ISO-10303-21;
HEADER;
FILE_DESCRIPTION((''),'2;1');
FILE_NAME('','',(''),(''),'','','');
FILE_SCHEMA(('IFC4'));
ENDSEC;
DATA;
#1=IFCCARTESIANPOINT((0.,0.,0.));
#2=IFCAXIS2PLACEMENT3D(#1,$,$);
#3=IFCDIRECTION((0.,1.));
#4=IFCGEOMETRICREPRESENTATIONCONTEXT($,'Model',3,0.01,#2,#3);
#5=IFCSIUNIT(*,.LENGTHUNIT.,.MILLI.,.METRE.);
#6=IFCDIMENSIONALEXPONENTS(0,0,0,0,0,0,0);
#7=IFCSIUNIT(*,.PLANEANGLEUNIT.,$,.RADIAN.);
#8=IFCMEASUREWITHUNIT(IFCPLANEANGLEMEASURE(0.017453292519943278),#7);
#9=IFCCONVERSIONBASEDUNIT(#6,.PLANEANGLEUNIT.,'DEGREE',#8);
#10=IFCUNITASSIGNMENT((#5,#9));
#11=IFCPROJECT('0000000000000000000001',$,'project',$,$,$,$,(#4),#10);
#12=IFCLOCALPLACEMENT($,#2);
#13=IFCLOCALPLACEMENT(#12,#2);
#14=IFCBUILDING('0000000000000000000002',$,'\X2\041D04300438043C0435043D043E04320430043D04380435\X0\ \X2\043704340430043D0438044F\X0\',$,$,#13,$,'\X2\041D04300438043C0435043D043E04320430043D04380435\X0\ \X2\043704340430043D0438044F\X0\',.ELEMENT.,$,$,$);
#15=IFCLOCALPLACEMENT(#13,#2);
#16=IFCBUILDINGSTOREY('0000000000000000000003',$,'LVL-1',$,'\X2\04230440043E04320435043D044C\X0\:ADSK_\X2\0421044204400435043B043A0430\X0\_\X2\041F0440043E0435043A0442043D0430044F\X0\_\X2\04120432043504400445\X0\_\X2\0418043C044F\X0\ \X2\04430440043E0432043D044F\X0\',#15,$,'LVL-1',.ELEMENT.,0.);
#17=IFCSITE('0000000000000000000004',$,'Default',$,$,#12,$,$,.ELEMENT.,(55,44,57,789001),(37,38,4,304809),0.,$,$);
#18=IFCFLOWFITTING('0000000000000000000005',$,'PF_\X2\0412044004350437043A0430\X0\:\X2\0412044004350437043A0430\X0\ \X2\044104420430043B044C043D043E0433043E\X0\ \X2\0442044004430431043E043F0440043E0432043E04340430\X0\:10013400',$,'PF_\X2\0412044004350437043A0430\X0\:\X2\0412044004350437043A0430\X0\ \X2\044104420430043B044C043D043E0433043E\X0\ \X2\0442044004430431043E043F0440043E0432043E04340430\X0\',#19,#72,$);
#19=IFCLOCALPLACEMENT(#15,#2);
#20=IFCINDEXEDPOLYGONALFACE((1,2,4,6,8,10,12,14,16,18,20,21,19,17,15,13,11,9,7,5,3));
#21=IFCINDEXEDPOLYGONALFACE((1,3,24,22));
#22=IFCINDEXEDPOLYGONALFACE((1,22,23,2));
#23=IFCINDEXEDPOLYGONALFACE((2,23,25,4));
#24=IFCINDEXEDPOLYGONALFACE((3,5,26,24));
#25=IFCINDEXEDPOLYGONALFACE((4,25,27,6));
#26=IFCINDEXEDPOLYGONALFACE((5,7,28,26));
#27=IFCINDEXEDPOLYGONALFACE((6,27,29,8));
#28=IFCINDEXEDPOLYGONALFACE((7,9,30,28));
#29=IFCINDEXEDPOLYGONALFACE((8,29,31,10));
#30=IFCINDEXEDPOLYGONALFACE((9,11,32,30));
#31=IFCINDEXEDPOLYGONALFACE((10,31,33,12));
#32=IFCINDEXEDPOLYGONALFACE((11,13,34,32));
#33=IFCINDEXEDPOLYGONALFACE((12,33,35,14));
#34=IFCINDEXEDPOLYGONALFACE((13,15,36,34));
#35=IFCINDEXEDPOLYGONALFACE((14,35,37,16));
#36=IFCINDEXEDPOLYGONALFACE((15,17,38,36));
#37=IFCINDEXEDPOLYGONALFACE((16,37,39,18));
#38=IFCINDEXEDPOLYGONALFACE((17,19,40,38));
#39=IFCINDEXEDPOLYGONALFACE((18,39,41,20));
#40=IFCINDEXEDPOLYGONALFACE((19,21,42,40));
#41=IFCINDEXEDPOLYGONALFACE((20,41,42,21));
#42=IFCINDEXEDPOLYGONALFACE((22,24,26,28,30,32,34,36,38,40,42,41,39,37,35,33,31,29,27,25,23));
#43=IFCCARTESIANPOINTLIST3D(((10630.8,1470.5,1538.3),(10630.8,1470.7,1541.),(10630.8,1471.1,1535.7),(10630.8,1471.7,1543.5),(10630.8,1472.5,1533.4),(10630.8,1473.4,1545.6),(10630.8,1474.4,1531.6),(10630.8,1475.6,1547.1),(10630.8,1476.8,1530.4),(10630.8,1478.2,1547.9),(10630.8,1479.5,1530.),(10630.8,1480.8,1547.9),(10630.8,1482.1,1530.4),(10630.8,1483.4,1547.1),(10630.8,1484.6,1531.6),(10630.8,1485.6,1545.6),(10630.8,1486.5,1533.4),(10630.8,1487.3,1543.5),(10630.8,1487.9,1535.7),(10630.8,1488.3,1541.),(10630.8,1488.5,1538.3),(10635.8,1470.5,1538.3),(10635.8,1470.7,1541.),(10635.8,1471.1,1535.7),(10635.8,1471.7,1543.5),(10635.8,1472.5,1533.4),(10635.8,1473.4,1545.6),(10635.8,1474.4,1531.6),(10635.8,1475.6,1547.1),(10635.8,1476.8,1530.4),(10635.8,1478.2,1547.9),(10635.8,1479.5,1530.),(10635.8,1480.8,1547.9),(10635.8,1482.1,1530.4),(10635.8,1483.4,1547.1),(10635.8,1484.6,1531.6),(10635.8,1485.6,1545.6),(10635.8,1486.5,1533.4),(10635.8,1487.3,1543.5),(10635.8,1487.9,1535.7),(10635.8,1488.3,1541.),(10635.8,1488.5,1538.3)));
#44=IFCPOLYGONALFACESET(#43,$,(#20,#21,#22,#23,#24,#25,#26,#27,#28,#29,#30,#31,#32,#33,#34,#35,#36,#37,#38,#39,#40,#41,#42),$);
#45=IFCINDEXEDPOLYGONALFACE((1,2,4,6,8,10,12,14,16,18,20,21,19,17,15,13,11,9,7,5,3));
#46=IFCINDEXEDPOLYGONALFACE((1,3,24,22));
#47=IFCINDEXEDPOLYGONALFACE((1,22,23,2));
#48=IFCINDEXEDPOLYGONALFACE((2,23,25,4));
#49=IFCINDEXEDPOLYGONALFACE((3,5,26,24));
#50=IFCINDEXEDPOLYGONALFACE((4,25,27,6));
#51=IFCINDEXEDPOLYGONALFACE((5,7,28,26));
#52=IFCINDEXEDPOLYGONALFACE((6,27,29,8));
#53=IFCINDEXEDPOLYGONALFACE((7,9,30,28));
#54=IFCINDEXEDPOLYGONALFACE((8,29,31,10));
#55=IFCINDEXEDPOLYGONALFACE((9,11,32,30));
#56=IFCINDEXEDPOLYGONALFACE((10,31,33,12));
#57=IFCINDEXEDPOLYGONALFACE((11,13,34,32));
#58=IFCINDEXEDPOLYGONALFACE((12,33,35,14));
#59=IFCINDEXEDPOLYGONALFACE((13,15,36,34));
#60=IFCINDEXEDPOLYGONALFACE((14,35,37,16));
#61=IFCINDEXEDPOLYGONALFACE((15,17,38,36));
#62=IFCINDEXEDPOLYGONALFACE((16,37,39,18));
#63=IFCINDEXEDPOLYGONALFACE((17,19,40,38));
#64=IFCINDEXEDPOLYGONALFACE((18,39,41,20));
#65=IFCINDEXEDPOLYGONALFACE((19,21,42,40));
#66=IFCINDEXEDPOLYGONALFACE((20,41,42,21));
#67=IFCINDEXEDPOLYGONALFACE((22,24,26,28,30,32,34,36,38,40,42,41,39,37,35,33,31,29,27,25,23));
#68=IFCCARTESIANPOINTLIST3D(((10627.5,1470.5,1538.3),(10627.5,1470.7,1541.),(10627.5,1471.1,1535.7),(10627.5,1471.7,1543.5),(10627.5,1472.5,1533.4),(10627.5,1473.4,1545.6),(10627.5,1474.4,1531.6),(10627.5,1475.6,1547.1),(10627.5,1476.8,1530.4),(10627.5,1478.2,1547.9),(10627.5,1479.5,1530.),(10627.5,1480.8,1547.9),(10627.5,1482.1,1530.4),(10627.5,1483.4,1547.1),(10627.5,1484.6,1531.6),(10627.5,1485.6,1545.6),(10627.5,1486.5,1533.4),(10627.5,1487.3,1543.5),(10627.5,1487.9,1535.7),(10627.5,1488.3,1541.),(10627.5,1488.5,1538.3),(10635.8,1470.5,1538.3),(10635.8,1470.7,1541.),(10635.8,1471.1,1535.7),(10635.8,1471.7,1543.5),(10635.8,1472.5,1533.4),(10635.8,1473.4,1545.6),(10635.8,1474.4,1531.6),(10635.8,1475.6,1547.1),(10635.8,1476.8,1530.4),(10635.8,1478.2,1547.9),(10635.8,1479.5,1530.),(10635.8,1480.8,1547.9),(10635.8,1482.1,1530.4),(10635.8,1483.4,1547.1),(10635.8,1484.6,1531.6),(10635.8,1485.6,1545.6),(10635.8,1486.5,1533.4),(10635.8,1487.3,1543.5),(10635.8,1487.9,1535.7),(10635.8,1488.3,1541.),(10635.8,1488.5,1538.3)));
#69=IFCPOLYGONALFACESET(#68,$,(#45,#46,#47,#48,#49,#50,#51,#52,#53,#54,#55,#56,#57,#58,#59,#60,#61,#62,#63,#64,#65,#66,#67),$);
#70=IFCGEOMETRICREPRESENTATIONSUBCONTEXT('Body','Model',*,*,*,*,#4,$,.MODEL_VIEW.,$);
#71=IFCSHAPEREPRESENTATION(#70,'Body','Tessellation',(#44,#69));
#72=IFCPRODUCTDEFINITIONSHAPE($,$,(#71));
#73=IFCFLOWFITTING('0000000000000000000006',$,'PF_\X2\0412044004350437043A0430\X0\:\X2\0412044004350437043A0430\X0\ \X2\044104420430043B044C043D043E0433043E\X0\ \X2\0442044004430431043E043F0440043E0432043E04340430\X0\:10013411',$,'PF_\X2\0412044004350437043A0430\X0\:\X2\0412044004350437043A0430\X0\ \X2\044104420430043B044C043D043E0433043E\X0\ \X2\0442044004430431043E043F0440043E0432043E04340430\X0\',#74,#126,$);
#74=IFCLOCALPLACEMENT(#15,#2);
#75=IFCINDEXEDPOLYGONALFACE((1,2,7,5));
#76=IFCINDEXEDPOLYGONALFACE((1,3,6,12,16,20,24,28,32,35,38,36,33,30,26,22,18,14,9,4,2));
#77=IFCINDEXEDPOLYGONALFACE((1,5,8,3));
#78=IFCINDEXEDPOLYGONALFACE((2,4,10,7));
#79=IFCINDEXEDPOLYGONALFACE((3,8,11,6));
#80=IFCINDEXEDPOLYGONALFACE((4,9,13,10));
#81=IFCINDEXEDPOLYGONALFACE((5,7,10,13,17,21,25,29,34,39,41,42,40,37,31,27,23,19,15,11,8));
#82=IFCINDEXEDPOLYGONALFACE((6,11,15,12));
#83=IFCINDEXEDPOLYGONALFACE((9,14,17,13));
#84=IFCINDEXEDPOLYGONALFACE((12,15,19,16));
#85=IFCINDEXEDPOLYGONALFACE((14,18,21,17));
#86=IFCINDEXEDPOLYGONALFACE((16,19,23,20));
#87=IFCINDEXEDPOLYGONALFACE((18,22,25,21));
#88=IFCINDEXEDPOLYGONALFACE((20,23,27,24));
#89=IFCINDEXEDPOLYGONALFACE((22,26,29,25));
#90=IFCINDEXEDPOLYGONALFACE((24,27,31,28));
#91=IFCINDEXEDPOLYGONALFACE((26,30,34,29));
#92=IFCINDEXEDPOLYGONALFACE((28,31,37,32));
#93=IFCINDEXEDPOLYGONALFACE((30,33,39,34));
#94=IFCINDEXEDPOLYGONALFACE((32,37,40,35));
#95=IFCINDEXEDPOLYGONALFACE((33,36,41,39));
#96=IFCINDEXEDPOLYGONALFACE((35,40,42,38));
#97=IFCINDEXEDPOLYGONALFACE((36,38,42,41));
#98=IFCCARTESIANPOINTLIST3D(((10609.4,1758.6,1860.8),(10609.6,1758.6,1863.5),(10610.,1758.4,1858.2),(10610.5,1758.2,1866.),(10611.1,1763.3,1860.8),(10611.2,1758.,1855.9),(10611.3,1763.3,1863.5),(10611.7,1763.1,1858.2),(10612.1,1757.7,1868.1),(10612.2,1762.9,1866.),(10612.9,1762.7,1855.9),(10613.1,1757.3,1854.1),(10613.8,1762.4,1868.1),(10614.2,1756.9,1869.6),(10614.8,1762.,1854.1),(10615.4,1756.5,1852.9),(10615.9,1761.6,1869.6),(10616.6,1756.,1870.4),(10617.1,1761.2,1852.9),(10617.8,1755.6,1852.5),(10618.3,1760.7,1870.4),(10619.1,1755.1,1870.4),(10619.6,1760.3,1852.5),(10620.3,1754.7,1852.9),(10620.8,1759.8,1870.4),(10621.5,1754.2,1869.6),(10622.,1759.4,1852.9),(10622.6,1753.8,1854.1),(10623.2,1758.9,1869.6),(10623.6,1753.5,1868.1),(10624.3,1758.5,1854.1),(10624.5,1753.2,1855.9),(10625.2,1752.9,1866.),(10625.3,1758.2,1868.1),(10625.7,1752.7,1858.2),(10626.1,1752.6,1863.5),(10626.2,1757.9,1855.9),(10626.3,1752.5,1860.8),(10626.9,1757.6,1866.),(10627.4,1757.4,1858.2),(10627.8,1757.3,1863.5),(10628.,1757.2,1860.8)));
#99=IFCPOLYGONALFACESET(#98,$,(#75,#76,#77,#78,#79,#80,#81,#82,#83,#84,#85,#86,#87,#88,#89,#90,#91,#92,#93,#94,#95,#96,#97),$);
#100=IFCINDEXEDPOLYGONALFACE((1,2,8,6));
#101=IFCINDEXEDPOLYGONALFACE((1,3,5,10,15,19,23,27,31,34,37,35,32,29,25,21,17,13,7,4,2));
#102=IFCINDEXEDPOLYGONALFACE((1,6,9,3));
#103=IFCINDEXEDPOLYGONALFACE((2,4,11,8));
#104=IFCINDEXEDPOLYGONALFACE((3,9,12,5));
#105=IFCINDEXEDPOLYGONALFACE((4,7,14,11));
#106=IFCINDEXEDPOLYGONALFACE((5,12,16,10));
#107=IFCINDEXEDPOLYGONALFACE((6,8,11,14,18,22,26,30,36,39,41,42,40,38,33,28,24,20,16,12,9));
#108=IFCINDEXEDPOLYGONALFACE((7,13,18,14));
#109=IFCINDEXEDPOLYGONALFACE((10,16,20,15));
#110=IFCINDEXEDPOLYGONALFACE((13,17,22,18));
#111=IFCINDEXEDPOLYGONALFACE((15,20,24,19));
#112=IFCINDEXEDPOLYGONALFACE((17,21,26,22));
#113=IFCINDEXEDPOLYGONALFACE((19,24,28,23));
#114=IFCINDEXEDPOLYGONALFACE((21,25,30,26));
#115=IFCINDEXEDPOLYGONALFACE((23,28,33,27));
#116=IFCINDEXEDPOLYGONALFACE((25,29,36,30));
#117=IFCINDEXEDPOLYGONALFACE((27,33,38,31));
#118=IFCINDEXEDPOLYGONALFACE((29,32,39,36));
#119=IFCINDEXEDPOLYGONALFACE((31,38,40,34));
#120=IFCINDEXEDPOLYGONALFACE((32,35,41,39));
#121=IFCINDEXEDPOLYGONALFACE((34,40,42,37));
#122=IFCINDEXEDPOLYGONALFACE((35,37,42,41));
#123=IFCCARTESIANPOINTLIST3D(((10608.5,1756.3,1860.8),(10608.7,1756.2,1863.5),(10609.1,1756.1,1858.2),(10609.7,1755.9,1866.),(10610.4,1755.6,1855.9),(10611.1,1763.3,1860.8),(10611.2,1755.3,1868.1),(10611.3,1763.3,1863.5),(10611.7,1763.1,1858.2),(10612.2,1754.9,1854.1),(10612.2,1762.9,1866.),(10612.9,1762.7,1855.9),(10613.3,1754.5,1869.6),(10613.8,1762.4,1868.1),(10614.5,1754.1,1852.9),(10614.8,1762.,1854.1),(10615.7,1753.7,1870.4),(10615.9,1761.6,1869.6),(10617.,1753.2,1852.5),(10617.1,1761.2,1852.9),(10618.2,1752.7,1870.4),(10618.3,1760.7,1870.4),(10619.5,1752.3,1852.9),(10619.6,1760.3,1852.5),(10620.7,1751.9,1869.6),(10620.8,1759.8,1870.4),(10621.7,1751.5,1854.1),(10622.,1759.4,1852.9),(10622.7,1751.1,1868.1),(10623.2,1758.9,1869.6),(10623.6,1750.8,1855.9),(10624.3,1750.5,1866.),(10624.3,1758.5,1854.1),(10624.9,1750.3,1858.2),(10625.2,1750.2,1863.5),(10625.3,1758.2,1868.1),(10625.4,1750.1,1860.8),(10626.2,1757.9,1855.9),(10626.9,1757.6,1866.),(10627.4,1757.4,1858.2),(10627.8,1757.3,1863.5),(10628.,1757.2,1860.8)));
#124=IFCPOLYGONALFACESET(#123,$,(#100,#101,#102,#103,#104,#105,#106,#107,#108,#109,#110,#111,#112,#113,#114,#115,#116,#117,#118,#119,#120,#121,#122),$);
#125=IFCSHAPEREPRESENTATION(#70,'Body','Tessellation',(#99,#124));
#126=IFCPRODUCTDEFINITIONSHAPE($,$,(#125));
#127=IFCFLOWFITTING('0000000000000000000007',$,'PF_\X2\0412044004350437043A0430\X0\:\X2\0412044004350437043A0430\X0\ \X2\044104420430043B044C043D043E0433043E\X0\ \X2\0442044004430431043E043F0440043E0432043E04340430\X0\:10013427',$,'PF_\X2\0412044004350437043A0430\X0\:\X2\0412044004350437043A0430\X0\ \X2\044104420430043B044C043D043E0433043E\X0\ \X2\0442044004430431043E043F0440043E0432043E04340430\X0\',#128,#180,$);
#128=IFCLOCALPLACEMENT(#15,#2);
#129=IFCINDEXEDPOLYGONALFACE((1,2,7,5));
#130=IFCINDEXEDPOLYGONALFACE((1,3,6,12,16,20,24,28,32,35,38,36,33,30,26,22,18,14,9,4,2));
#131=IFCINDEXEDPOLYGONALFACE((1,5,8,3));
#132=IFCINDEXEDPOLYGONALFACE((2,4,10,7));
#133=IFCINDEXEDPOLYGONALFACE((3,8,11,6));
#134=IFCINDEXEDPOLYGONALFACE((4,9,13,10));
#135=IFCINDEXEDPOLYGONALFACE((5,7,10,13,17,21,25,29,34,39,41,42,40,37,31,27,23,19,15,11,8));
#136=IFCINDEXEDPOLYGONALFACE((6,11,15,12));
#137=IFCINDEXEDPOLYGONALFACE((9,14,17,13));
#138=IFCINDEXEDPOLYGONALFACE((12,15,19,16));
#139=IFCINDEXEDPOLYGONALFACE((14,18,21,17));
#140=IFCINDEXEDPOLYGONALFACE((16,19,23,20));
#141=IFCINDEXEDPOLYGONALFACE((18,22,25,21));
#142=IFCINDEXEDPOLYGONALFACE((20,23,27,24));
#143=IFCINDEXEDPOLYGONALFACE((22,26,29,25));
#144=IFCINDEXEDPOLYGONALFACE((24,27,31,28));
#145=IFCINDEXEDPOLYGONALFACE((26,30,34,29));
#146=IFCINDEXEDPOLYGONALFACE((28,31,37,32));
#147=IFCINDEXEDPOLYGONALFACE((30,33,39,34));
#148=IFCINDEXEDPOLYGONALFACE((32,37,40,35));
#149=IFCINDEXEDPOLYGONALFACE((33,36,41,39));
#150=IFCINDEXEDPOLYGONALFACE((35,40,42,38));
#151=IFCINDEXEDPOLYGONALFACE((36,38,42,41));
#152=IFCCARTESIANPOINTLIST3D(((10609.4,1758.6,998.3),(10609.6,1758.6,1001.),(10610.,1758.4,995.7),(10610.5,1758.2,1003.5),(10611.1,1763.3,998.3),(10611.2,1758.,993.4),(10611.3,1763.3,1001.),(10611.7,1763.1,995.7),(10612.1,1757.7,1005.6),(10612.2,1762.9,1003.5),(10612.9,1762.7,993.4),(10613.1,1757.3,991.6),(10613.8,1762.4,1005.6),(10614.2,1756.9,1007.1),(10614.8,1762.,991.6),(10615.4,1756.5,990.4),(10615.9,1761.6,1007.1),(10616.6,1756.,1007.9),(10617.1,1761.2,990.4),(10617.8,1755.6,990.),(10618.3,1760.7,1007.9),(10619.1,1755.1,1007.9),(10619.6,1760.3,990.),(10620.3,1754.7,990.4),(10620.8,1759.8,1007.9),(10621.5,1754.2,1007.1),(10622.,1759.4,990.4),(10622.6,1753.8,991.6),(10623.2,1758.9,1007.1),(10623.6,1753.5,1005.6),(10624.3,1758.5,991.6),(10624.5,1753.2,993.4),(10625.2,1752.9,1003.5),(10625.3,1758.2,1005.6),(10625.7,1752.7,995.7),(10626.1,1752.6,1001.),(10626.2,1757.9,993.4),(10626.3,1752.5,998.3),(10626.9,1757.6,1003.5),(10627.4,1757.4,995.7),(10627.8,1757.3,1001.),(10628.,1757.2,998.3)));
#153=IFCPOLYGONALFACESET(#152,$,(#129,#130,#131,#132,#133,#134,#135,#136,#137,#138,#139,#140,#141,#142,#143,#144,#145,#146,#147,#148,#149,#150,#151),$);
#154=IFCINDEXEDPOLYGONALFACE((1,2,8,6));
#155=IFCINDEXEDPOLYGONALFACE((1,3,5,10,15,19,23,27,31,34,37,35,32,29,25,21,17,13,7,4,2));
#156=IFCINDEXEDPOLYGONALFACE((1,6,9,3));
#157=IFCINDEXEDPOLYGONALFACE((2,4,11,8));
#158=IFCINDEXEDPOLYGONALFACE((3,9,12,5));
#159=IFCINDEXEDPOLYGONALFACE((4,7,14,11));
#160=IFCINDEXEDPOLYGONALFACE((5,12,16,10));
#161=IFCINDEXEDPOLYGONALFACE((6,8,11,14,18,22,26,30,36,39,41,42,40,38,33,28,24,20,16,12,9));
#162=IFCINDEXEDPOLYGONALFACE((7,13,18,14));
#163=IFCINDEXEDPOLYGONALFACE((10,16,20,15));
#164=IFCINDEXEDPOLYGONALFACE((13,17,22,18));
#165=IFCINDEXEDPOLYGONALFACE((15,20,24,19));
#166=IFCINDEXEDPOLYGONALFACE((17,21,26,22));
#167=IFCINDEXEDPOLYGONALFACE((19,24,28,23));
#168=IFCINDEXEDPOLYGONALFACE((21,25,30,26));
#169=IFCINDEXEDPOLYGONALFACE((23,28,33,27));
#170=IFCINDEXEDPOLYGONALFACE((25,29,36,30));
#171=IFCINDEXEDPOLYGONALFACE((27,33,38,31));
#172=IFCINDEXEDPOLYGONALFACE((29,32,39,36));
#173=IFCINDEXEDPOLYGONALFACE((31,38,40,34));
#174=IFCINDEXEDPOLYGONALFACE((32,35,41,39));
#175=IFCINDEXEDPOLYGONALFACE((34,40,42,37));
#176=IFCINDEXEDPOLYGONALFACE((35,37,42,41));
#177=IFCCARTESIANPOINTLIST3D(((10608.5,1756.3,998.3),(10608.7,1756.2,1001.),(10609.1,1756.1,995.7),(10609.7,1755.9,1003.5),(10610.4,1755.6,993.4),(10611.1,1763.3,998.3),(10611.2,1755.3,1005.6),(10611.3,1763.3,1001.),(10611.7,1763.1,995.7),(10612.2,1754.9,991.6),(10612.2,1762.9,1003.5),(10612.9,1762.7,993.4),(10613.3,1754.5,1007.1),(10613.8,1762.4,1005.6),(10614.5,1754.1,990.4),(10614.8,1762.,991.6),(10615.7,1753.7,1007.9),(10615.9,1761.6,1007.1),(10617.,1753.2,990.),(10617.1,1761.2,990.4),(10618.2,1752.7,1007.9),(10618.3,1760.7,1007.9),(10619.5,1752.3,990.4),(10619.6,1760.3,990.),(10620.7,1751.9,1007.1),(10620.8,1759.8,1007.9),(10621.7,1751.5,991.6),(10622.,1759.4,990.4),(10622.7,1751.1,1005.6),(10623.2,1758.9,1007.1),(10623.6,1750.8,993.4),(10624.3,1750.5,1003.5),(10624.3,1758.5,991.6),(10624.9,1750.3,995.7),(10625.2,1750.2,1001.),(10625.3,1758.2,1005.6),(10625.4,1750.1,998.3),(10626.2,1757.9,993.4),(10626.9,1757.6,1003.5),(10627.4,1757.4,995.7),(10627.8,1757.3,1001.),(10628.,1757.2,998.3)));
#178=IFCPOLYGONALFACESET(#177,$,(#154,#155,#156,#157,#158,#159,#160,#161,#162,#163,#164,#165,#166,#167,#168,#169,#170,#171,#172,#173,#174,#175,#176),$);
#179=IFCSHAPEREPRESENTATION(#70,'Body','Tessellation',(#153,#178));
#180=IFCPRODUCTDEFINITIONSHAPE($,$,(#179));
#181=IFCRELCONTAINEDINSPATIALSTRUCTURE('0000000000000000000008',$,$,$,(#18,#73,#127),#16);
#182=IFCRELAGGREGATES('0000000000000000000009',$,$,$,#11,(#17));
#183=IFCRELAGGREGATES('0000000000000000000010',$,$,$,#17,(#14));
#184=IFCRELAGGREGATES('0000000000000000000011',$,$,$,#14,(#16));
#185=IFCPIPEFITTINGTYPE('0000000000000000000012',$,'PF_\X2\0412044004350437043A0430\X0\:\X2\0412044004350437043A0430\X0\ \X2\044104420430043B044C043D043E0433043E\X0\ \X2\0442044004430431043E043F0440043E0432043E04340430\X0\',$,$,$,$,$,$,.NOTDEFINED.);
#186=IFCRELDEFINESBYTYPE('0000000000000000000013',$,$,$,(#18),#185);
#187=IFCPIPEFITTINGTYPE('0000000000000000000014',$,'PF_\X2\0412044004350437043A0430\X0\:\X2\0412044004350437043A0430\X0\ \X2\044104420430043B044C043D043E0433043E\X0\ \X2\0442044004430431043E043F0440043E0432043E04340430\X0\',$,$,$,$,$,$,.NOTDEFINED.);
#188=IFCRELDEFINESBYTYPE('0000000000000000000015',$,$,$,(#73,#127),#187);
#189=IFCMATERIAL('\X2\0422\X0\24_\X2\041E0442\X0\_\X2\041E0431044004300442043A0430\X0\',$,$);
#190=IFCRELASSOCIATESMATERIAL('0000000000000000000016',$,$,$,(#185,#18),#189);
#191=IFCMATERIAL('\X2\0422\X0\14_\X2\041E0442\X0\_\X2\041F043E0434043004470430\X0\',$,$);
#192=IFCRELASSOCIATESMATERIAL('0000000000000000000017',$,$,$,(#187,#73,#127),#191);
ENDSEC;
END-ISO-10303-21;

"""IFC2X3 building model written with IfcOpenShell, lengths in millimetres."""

from ifc_helpers import new_model, entity, si_unit, converted_unit, direction, frame, frame_2d, origin, place, context, subcontext, project, spatial, circle, extrude, source, transform, mapped, material, type_object, type_shapes, element, save


model = new_model("IFC2X3")

# Units and contexts
model_context = context("Model", 3, precision=0.01, world=origin(), true_north=direction((0.0, 1.0)))
body_context = subcontext(model_context, "Body", "Model", "MODEL_VIEW")
ifc_project = project(units=[si_unit("LENGTHUNIT", "METRE", prefix="MILLI"), converted_unit("PLANEANGLEUNIT", "DEGREE", entity("IfcPlaneAngleMeasure", 0.017453292519943278), si_unit("PLANEANGLEUNIT", "RADIAN"), dimensions=[0, 0, 0, 0, 0, 0, 0])], contexts=[model_context])

# Site, building, storey
site_placement = place(None, origin())
site = spatial("IfcSite", under=ifc_project, at=site_placement, Name="Default", CompositionType="ELEMENT", RefLatitude=(55, 44, 57, 789001), RefLongitude=(37, 38, 4, 304809), RefElevation=0.0)
building_placement = place(site_placement, origin())
building = spatial("IfcBuilding", under=site, at=building_placement, Name="Наименование здания", LongName="Наименование здания", CompositionType="ELEMENT")
storey_placement = place(building_placement, origin())
storey = spatial("IfcBuildingStorey", under=building, at=storey_placement, Name="LVL-1", ObjectType="Уровень:ADSK_Стрелка_Проектная_Вверх_Имя уровня", LongName="LVL-1", CompositionType="ELEMENT", Elevation=0.0)

# Flow fittings
ifc_material_1 = material(Name="Т24_От_Обратка")
pipe_fitting_type_1 = type_object("IfcPipeFittingType", Name="PF_Врезка:Врезка стального трубопровода", PredefinedType="NOTDEFINED", material=ifc_material_1)
shared_shape_1 = source(origin(), body_context, "Body", "SweptSolid", [
    extrude(circle(Radius=9.0, at=frame_2d((0.0, 0.0), x_axis=(1.0, 0.0))), frame((-5.0, 0.0, 0.0), z_axis=(1.0, 0.0, 0.0), x_axis=(0.0, -1.0, 0.0)), (0.0, 0.0, 1.0), 5.0),
    extrude(circle(Radius=9.0, at=frame_2d((0.0, 0.0), x_axis=(1.0, 0.0))), frame((-8.3, 0.0, 0.0), z_axis=(1.0, 0.0, 0.0), x_axis=(0.0, -1.0, 0.0)), (0.0, 0.0, 1.0), 8.3),
])
type_shapes(pipe_fitting_type_1, [shared_shape_1])
flow_fitting_1_placement = place(storey_placement, frame((10635.8, 1479.5, 1539.0), z_axis=(0.0, -1.0, 0.0), x_axis=(1.0, 0.0, 0.0)))
element("IfcFlowFitting", 1, at=flow_fitting_1_placement, inside=storey, type_object=pipe_fitting_type_1, material=ifc_material_1, Name="PF_Врезка:Врезка стального трубопровода:10013400", ObjectType="PF_Врезка:Врезка стального трубопровода", context=body_context, shape_type="MappedRepresentation", body=[
    mapped(shared_shape_1, transform((0.0, 0.0, 0.0), scale=1.0)),
])
ifc_material_2 = material(Name="Т14_От_Подача")
pipe_fitting_type_2 = type_object("IfcPipeFittingType", Name="PF_Врезка:Врезка стального трубопровода", PredefinedType="NOTDEFINED", material=ifc_material_2)
shared_shape_2 = source(origin(), body_context, "Body", "SweptSolid", [
    extrude(circle(Radius=9.0, at=frame_2d((0.0, 0.0), x_axis=(1.0, 0.0))), frame((-5.0, 0.0, 0.0), z_axis=(1.0, 0.0, 0.0), x_axis=(0.0, -1.0, 0.0)), (0.0, 0.0, 1.0), 5.0),
    extrude(circle(Radius=9.0, at=frame_2d((0.0, 0.0), x_axis=(1.0, 0.0))), frame((-7.5, 0.0, 0.0), z_axis=(1.0, 0.0, 0.0), x_axis=(0.0, -1.0, 0.0)), (0.0, 0.0, 1.0), 7.5),
])
type_shapes(pipe_fitting_type_2, [shared_shape_2])
for number, where, z_axis, x_axis, name in (
    (2, (10619.6, 1760.3, 1861.5), (0.939693, -0.34202, 0.0), (0.34202, 0.939693, 0.0), "PF_Врезка:Врезка стального трубопровода:10013411"),
    (3, (10619.6, 1760.3, 999.0), (0.939693, -0.34202, 0.0), (0.34202, 0.939693, 0.0), "PF_Врезка:Врезка стального трубопровода:10013427"),
):
    element("IfcFlowFitting", number, at=place(storey_placement, frame(where, z_axis=z_axis, x_axis=x_axis)), inside=storey, type_object=pipe_fitting_type_2, material=ifc_material_2, Name=name, ObjectType="PF_Врезка:Врезка стального трубопровода", context=body_context, shape_type="MappedRepresentation", body=[
        mapped(shared_shape_2, transform((0.0, 0.0, 0.0), scale=1.0)),
    ])

save(model, "model.ifc")
